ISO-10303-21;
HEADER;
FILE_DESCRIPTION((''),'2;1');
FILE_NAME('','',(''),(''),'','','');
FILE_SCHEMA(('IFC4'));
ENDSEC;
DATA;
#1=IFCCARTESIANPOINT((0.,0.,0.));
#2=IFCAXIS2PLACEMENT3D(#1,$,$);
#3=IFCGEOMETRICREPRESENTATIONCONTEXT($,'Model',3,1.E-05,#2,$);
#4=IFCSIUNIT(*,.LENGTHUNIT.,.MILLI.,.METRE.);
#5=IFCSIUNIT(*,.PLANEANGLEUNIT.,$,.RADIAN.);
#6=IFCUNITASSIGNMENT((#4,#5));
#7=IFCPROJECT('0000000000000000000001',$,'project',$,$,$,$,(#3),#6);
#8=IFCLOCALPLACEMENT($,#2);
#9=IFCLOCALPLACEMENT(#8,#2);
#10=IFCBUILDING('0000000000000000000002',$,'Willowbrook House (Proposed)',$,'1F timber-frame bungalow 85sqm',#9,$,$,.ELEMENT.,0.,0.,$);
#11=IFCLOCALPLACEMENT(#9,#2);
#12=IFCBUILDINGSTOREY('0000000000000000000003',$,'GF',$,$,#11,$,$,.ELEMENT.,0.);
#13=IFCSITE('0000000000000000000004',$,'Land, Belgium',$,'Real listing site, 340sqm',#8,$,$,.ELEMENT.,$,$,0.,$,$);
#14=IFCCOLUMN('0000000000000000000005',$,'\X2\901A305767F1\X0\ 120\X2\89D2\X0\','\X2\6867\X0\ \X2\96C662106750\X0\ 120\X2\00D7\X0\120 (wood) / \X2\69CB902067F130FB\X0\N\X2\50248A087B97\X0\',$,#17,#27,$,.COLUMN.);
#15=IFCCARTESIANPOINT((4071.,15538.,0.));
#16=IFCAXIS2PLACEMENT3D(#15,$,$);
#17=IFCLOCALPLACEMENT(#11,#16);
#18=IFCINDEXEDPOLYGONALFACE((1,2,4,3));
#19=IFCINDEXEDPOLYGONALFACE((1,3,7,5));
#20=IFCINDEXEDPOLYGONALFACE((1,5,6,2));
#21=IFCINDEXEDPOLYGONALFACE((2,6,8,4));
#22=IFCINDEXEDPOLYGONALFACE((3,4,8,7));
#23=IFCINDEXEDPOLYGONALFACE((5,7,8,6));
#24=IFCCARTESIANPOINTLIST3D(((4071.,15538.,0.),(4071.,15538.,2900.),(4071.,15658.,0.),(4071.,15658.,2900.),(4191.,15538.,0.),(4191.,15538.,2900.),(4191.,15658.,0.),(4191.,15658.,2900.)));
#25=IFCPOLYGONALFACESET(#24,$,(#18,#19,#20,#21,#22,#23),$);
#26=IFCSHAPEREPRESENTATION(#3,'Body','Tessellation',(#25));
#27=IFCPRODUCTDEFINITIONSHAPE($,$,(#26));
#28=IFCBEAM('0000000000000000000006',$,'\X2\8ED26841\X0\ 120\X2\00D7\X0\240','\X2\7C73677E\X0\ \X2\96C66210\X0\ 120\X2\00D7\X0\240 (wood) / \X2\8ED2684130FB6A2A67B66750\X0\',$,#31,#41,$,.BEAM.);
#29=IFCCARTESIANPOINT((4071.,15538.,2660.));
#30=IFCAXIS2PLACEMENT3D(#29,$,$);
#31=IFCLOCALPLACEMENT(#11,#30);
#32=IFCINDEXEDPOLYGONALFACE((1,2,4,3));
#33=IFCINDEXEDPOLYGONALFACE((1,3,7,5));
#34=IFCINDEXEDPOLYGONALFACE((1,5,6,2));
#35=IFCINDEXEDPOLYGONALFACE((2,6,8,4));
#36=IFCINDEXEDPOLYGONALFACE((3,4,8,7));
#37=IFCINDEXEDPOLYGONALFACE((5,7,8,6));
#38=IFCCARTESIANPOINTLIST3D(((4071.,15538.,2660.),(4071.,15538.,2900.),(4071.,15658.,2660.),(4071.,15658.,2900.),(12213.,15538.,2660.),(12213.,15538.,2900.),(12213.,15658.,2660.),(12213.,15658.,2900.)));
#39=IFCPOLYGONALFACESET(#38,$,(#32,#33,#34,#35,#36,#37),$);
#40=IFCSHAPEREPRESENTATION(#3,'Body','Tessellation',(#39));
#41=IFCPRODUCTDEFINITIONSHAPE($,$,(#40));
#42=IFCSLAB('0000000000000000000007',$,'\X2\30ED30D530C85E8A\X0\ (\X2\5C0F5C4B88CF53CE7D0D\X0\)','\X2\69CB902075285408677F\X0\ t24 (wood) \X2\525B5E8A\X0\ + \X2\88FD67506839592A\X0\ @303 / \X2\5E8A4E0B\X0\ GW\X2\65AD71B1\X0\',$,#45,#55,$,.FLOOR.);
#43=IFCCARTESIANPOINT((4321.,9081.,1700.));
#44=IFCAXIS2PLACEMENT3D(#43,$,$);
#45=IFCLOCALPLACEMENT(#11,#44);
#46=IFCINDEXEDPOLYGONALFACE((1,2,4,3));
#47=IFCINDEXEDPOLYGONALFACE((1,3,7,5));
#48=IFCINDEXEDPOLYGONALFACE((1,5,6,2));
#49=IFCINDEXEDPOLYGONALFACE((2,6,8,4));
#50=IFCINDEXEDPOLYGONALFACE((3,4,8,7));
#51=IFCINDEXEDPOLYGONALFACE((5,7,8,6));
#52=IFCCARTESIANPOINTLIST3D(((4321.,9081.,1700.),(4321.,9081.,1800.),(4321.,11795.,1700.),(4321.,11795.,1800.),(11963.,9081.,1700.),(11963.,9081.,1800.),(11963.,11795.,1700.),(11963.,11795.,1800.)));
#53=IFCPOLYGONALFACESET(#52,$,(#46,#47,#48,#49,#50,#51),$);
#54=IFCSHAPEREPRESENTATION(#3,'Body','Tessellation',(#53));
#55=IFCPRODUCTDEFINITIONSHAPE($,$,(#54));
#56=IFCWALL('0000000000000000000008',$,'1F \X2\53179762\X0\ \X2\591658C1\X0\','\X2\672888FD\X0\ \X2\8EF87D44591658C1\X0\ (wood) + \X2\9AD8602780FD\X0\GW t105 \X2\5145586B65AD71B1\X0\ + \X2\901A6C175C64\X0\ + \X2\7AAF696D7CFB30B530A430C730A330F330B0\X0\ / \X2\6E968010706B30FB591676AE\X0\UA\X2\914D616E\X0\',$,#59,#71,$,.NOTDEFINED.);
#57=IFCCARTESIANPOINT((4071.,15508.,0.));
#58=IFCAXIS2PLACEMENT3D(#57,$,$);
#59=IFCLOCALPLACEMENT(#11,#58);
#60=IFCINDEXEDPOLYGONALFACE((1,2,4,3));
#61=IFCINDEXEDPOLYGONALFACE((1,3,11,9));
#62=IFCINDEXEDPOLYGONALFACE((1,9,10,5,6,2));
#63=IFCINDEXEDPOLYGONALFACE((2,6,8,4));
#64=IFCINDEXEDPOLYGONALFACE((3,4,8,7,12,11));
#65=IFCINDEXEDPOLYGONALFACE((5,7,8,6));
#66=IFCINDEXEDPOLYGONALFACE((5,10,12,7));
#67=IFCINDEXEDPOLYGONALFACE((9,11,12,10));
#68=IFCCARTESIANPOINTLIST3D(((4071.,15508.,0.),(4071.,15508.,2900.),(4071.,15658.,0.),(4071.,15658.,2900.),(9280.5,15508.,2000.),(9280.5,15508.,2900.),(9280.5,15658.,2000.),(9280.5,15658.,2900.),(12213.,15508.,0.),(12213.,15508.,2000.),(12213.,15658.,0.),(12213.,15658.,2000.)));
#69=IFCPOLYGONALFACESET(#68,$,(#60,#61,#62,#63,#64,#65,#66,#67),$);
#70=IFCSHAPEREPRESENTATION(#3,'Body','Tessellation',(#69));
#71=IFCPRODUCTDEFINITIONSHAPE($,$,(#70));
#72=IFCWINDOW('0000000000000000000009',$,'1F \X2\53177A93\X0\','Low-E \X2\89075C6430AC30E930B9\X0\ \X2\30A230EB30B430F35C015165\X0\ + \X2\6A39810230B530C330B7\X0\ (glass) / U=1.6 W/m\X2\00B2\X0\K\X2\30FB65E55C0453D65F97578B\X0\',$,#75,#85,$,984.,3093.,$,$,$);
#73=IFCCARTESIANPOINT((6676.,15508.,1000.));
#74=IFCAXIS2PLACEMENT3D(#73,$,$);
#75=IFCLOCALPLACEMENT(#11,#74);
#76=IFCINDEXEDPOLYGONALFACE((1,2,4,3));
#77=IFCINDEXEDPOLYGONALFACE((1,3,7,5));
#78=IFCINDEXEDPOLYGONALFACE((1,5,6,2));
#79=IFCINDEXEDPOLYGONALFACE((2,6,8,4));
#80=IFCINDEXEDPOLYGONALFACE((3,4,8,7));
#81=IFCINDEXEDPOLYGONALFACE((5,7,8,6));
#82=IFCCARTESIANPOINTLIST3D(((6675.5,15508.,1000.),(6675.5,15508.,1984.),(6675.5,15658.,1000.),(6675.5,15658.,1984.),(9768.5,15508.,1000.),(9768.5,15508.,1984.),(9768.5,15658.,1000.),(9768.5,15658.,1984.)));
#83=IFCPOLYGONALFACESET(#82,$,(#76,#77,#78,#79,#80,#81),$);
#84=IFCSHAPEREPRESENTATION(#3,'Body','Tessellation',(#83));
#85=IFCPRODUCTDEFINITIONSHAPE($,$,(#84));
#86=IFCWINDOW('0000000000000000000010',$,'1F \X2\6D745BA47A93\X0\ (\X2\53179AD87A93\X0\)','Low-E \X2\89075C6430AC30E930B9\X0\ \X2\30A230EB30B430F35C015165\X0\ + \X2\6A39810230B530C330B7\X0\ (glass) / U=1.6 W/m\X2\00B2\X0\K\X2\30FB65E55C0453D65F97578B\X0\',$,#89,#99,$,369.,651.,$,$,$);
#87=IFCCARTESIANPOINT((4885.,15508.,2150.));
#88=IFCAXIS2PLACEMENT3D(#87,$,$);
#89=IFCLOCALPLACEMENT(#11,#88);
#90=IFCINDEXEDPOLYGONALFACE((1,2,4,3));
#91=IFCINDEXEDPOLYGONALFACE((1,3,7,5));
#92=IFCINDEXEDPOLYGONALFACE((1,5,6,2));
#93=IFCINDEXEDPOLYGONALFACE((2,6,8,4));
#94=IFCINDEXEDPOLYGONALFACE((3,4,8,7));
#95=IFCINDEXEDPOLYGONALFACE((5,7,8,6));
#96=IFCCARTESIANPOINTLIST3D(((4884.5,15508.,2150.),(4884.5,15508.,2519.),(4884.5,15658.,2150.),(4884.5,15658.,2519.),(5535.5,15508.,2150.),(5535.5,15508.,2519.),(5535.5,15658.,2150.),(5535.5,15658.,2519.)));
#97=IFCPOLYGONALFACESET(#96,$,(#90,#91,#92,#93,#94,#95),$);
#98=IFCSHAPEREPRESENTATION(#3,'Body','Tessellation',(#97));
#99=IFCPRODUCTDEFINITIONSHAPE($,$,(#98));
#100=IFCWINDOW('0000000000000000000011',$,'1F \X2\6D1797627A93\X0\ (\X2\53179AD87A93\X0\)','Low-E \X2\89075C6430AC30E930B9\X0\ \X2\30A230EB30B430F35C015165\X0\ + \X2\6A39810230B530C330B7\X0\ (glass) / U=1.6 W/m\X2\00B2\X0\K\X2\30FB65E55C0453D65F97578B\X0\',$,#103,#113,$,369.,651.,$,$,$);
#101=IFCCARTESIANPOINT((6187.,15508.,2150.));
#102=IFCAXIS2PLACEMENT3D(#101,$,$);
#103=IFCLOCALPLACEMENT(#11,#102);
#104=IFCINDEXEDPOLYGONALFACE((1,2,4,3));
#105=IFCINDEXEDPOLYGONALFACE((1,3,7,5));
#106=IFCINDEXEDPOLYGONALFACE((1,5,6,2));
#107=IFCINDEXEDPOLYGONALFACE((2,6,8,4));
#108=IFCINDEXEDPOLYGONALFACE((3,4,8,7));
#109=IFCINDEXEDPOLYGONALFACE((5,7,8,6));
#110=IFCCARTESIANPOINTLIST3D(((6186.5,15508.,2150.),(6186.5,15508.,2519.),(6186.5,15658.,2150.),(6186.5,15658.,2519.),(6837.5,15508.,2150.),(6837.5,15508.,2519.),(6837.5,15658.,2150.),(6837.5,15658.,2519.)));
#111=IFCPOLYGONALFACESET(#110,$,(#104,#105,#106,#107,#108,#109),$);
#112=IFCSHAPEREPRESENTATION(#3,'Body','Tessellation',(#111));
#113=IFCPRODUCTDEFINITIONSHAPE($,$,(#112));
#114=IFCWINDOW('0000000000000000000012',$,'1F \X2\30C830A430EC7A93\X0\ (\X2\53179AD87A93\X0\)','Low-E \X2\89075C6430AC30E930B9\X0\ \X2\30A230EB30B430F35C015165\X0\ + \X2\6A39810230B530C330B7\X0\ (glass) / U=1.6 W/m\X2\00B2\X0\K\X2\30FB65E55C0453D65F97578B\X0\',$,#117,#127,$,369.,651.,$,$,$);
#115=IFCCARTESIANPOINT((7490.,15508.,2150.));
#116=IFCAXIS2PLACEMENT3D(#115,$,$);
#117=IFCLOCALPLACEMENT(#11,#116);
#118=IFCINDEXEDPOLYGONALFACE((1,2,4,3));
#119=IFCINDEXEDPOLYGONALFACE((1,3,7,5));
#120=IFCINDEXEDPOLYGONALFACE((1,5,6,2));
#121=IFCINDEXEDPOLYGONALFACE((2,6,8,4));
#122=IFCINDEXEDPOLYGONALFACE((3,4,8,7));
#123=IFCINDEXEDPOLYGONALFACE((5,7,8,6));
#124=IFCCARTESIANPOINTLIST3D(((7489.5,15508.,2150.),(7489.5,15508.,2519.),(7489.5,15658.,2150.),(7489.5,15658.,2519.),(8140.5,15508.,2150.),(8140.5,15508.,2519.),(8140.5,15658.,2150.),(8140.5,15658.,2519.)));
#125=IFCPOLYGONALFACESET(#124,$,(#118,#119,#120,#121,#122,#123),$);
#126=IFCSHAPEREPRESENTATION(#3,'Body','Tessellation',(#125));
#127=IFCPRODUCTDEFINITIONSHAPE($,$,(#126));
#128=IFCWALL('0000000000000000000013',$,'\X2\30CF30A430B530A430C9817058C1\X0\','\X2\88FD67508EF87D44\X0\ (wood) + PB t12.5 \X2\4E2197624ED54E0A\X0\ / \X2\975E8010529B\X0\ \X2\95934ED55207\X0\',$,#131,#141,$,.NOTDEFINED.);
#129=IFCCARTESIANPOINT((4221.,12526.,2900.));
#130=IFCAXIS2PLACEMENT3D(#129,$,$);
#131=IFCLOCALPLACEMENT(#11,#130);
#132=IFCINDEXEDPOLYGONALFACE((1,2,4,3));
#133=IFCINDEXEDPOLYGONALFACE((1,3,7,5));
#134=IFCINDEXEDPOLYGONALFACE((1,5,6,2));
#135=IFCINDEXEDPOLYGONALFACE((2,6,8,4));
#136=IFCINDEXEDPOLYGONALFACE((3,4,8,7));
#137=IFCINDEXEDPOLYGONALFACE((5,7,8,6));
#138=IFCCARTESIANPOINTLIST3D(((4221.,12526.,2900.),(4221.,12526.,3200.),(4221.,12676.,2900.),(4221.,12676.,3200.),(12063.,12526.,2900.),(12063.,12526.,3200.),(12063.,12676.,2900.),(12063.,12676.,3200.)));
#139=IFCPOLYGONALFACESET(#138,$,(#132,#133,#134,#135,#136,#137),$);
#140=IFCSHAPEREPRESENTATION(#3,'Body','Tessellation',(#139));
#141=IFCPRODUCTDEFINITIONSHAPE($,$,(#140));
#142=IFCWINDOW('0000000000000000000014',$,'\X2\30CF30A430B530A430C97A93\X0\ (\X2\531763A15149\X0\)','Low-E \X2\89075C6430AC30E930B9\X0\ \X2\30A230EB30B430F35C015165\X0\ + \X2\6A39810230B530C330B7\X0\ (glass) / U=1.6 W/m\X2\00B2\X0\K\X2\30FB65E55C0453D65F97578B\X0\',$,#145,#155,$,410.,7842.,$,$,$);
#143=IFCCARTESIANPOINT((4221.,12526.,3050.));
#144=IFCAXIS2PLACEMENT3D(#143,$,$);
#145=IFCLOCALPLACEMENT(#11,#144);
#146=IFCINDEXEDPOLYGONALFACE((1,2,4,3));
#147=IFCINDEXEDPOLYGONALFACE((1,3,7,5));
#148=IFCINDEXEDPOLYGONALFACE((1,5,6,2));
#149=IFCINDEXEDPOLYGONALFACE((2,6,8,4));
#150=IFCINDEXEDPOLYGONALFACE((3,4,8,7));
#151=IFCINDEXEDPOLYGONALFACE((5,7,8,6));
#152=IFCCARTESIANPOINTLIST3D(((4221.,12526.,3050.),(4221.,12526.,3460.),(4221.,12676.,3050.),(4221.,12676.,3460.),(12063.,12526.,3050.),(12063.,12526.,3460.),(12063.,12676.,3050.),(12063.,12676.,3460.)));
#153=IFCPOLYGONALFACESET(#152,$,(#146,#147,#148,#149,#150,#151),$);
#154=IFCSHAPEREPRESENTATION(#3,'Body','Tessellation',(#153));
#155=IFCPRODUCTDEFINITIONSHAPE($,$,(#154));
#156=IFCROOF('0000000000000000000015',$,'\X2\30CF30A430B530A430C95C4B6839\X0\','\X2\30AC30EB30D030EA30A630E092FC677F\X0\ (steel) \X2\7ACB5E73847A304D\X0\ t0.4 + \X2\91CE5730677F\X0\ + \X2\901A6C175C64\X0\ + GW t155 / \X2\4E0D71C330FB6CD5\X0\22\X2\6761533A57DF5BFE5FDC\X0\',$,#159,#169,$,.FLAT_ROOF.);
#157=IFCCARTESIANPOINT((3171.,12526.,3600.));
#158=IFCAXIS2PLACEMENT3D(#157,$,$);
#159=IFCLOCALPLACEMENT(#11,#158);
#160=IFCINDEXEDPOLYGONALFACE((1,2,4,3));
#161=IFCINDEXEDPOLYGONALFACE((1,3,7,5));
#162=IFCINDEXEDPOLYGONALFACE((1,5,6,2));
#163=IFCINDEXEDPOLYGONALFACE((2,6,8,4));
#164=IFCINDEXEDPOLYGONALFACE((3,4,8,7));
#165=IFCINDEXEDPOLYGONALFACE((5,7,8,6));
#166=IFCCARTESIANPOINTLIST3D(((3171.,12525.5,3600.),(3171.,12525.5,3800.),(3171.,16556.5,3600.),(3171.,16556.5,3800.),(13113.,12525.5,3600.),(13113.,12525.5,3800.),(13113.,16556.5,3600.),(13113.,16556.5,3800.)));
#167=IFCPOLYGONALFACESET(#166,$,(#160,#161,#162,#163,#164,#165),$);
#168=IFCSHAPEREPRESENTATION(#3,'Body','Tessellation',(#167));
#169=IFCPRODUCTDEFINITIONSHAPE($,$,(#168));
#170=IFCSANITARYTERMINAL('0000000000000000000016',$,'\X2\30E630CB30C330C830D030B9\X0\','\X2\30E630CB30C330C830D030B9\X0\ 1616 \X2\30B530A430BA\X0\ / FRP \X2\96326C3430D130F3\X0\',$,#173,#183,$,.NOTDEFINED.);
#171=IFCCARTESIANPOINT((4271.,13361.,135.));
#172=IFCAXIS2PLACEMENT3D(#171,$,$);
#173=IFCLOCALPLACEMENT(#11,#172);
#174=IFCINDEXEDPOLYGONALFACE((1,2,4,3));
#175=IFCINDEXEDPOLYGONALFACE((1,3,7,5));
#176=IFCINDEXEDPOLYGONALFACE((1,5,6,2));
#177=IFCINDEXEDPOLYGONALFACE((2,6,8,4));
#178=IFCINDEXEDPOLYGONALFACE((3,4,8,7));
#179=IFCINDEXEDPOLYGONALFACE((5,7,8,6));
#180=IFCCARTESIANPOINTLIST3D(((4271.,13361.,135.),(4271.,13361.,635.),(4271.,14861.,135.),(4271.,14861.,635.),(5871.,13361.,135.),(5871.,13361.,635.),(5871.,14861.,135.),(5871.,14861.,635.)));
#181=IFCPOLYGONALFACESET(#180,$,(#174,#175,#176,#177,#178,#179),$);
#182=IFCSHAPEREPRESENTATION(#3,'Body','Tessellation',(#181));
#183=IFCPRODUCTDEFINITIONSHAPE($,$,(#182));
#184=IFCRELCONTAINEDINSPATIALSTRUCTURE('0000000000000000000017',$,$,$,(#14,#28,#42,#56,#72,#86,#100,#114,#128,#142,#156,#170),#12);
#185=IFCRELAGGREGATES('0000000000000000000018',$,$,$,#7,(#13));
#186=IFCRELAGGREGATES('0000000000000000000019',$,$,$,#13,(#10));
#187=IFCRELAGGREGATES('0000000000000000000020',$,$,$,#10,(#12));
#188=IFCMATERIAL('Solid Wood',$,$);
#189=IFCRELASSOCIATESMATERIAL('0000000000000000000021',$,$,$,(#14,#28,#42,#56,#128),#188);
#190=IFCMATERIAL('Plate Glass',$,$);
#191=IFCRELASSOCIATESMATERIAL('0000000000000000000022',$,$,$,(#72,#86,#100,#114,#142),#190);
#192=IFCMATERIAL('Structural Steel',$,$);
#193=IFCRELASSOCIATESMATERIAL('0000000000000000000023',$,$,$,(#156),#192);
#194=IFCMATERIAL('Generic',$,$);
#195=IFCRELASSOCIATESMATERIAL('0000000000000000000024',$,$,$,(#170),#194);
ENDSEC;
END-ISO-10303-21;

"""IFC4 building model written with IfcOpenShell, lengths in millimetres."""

from ifc_helpers import new_model, si_unit, frame, frame_2d, origin, place, context, project, spatial, rectangle, extrude, material, element, fill, save


model = new_model("IFC4")

# Units and contexts
model_context = context("Model", 3, precision=1e-05, world=origin())
ifc_project = project(units=[si_unit("LENGTHUNIT", "METRE", prefix="MILLI"), si_unit("PLANEANGLEUNIT", "RADIAN")], contexts=[model_context])

# Site, building, storey
site_placement = place(None, origin())
site = spatial("IfcSite", under=ifc_project, at=site_placement, Name="Land, Belgium", ObjectType="Real listing site, 340sqm", CompositionType="ELEMENT", RefElevation=0.0)
building_placement = place(site_placement, origin())
building = spatial("IfcBuilding", under=site, at=building_placement, Name="Willowbrook House (Proposed)", ObjectType="1F timber-frame bungalow 85sqm", CompositionType="ELEMENT", ElevationOfRefHeight=0.0, ElevationOfTerrain=0.0)
storey_placement = place(building_placement, origin())
storey = spatial("IfcBuildingStorey", under=building, at=storey_placement, Name="GF", CompositionType="ELEMENT", Elevation=0.0)

# Column
ifc_material_1 = material(Name="Solid Wood")
column_1_placement = place(storey_placement, frame((4071.0, 15538.0, 0.0)))
element("IfcColumn", 1, at=column_1_placement, inside=storey, material=ifc_material_1, Name="通し柱 120角", Description="桧 集成材 120×120 (wood) / 構造柱・N値計算", PredefinedType="COLUMN", context=model_context, shape_type="SweptSolid", body=[
    extrude(rectangle(XDim=120.0, YDim=120.0, at=frame_2d((60.0, 60.0))), frame((4071.0, 15538.0, 0.0)), (0.0, 0.0, 1.0), 2900.0),
])

# Beam
beam_1_placement = place(storey_placement, frame((4071.0, 15538.0, 2660.0)))
element("IfcBeam", 2, at=beam_1_placement, inside=storey, material=ifc_material_1, Name="軒桁 120×240", Description="米松 集成 120×240 (wood) / 軒桁・横架材", PredefinedType="BEAM", context=model_context, shape_type="SweptSolid", body=[
    extrude(rectangle(XDim=8142.0, YDim=120.0, at=frame_2d((4071.0, 60.0))), frame((4071.0, 15538.0, 2660.0)), (0.0, 0.0, 1.0), 240.0),
])

# Slab
slab_placement = place(storey_placement, frame((4321.0, 9081.0, 1700.0)))
element("IfcSlab", 3, at=slab_placement, inside=storey, material=ifc_material_1, Name="ロフト床 (小屋裏収納)", Description="構造用合板 t24 (wood) 剛床 + 製材根太 @303 / 床下 GW断熱", PredefinedType="FLOOR", context=model_context, shape_type="SweptSolid", body=[
    extrude(rectangle(XDim=7642.0, YDim=2714.0, at=frame_2d((3821.0, 1357.0))), frame((4321.0, 9081.0, 1700.0)), (0.0, 0.0, 1.0), 100.0),
])

# Wall, openings, windows
wall_1_placement = place(storey_placement, frame((4071.0, 15508.0, 0.0)))
wall_1 = element("IfcWall", 4, at=wall_1_placement, inside=storey, material=ifc_material_1, Name="1F 北面 外壁", Description="木製 軸組外壁 (wood) + 高性能GW t105 充填断熱 + 通気層 + 窯業系サイディング / 準耐火・外皮UA配慮", PredefinedType="NOTDEFINED", context=model_context, shape_type="SweptSolid", body=[
    extrude(rectangle(XDim=8142.0, YDim=150.0, at=frame_2d((4071.0, 75.0))), frame((4071.0, 15508.0, 0.0)), (0.0, 0.0, 1.0), 2900.0),
])
opening_1_placement = place(storey_placement, frame((6676.0, 15508.0, 1000.0)))
opening_1 = element("IfcOpeningElement", 5, at=opening_1_placement, cuts=wall_1, PredefinedType="NOTDEFINED", context=model_context, shape_type="SweptSolid", body=[
    extrude(rectangle(XDim=3093.0, YDim=150.0, at=frame_2d((1546.0, 75.0))), frame((6676.0, 15508.0, 1000.0)), (0.0, 0.0, 1.0), 984.0),
])
opening_2_placement = place(storey_placement, frame((4885.0, 15508.0, 2150.0)))
opening_2 = element("IfcOpeningElement", 6, at=opening_2_placement, cuts=wall_1, PredefinedType="NOTDEFINED", context=model_context, shape_type="SweptSolid", body=[
    extrude(rectangle(XDim=651.0, YDim=150.0, at=frame_2d((325.0, 75.0))), frame((4885.0, 15508.0, 2150.0)), (0.0, 0.0, 1.0), 369.0),
])
opening_3_placement = place(storey_placement, frame((6187.0, 15508.0, 2150.0)))
opening_3 = element("IfcOpeningElement", 7, at=opening_3_placement, cuts=wall_1, PredefinedType="NOTDEFINED", context=model_context, shape_type="SweptSolid", body=[
    extrude(rectangle(XDim=651.0, YDim=150.0, at=frame_2d((325.0, 75.0))), frame((6187.0, 15508.0, 2150.0)), (0.0, 0.0, 1.0), 369.0),
])
opening_4_placement = place(storey_placement, frame((7490.0, 15508.0, 2150.0)))
opening_4 = element("IfcOpeningElement", 8, at=opening_4_placement, cuts=wall_1, PredefinedType="NOTDEFINED", context=model_context, shape_type="SweptSolid", body=[
    extrude(rectangle(XDim=651.0, YDim=150.0, at=frame_2d((325.0, 75.0))), frame((7490.0, 15508.0, 2150.0)), (0.0, 0.0, 1.0), 369.0),
])
ifc_material_2 = material(Name="Plate Glass")
window_1_placement = place(storey_placement, frame((6676.0, 15508.0, 1000.0)))
window_1 = element("IfcWindow", 9, at=window_1_placement, inside=storey, material=ifc_material_2, Name="1F 北窓", Description="Low-E 複層ガラス アルゴン封入 + 樹脂サッシ (glass) / U=1.6 W/m²K・日射取得型", OverallHeight=984.0, OverallWidth=3093.0, context=model_context, shape_type="SweptSolid", body=[
    extrude(rectangle(XDim=3093.0, YDim=150.0, at=frame_2d((1546.0, 75.0))), frame((6676.0, 15508.0, 1000.0)), (0.0, 0.0, 1.0), 984.0),
])
fill(opening_1, window_1)
window_2_placement = place(storey_placement, frame((4885.0, 15508.0, 2150.0)))
window_2 = element("IfcWindow", 10, at=window_2_placement, inside=storey, material=ifc_material_2, Name="1F 浴室窓 (北高窓)", Description="Low-E 複層ガラス アルゴン封入 + 樹脂サッシ (glass) / U=1.6 W/m²K・日射取得型", OverallHeight=369.0, OverallWidth=651.0, context=model_context, shape_type="SweptSolid", body=[
    extrude(rectangle(XDim=651.0, YDim=150.0, at=frame_2d((325.0, 75.0))), frame((4885.0, 15508.0, 2150.0)), (0.0, 0.0, 1.0), 369.0),
])
fill(opening_2, window_2)
window_3_placement = place(storey_placement, frame((6187.0, 15508.0, 2150.0)))
window_3 = element("IfcWindow", 11, at=window_3_placement, inside=storey, material=ifc_material_2, Name="1F 洗面窓 (北高窓)", Description="Low-E 複層ガラス アルゴン封入 + 樹脂サッシ (glass) / U=1.6 W/m²K・日射取得型", OverallHeight=369.0, OverallWidth=651.0, context=model_context, shape_type="SweptSolid", body=[
    extrude(rectangle(XDim=651.0, YDim=150.0, at=frame_2d((325.0, 75.0))), frame((6187.0, 15508.0, 2150.0)), (0.0, 0.0, 1.0), 369.0),
])
fill(opening_3, window_3)
window_4_placement = place(storey_placement, frame((7490.0, 15508.0, 2150.0)))
window_4 = element("IfcWindow", 12, at=window_4_placement, inside=storey, material=ifc_material_2, Name="1F トイレ窓 (北高窓)", Description="Low-E 複層ガラス アルゴン封入 + 樹脂サッシ (glass) / U=1.6 W/m²K・日射取得型", OverallHeight=369.0, OverallWidth=651.0, context=model_context, shape_type="SweptSolid", body=[
    extrude(rectangle(XDim=651.0, YDim=150.0, at=frame_2d((325.0, 75.0))), frame((7490.0, 15508.0, 2150.0)), (0.0, 0.0, 1.0), 369.0),
])
fill(opening_4, window_4)

# Wall, opening, window
wall_2_placement = place(storey_placement, frame((4221.0, 12526.0, 2900.0)))
wall_2 = element("IfcWall", 13, at=wall_2_placement, inside=storey, material=ifc_material_1, Name="ハイサイド腰壁", Description="製材軸組 (wood) + PB t12.5 両面仕上 / 非耐力 間仕切", PredefinedType="NOTDEFINED", context=model_context, shape_type="SweptSolid", body=[
    extrude(rectangle(XDim=7842.0, YDim=150.0, at=frame_2d((3921.0, 75.0))), frame((4221.0, 12526.0, 2900.0)), (0.0, 0.0, 1.0), 700.0),
])
opening_5_placement = place(storey_placement, frame((4221.0, 12526.0, 3050.0)))
opening_5 = element("IfcOpeningElement", 14, at=opening_5_placement, cuts=wall_2, PredefinedType="NOTDEFINED", context=model_context, shape_type="SweptSolid", body=[
    extrude(rectangle(XDim=7842.0, YDim=150.0, at=frame_2d((3921.0, 75.0))), frame((4221.0, 12526.0, 3050.0)), (0.0, 0.0, 1.0), 410.0),
])
window_5_placement = place(storey_placement, frame((4221.0, 12526.0, 3050.0)))
window_5 = element("IfcWindow", 15, at=window_5_placement, inside=storey, material=ifc_material_2, Name="ハイサイド窓 (北採光)", Description="Low-E 複層ガラス アルゴン封入 + 樹脂サッシ (glass) / U=1.6 W/m²K・日射取得型", OverallHeight=410.0, OverallWidth=7842.0, context=model_context, shape_type="SweptSolid", body=[
    extrude(rectangle(XDim=7842.0, YDim=150.0, at=frame_2d((3921.0, 75.0))), frame((4221.0, 12526.0, 3050.0)), (0.0, 0.0, 1.0), 410.0),
])
fill(opening_5, window_5)

# Roof
ifc_material_3 = material(Name="Structural Steel")
roof_placement = place(storey_placement, frame((3171.0, 12526.0, 3600.0)))
element("IfcRoof", 16, at=roof_placement, inside=storey, material=ifc_material_3, Name="ハイサイド屋根", Description="ガルバリウム鋼板 (steel) 立平葺き t0.4 + 野地板 + 通気層 + GW t155 / 不燃・法22条区域対応", PredefinedType="FLAT_ROOF", context=model_context, shape_type="SweptSolid", body=[
    extrude(rectangle(XDim=9942.0, YDim=4031.0, at=frame_2d((4971.0, 2015.0))), frame((3171.0, 12526.0, 3600.0)), (0.0, 0.0, 1.0), 200.0),
])

# Sanitary terminal
ifc_material_4 = material(Name="Generic")
sanitary_terminal_placement = place(storey_placement, frame((4271.0, 13361.0, 135.0)))
element("IfcSanitaryTerminal", 17, at=sanitary_terminal_placement, inside=storey, material=ifc_material_4, Name="ユニットバス", Description="ユニットバス 1616 サイズ / FRP 防水パン", PredefinedType="NOTDEFINED", context=model_context, shape_type="SweptSolid", body=[
    extrude(rectangle(XDim=1600.0, YDim=1500.0, at=frame_2d((800.0, 750.0))), frame((4271.0, 13361.0, 135.0)), (0.0, 0.0, 1.0), 500.0),
])

save(model, "model.ifc")
